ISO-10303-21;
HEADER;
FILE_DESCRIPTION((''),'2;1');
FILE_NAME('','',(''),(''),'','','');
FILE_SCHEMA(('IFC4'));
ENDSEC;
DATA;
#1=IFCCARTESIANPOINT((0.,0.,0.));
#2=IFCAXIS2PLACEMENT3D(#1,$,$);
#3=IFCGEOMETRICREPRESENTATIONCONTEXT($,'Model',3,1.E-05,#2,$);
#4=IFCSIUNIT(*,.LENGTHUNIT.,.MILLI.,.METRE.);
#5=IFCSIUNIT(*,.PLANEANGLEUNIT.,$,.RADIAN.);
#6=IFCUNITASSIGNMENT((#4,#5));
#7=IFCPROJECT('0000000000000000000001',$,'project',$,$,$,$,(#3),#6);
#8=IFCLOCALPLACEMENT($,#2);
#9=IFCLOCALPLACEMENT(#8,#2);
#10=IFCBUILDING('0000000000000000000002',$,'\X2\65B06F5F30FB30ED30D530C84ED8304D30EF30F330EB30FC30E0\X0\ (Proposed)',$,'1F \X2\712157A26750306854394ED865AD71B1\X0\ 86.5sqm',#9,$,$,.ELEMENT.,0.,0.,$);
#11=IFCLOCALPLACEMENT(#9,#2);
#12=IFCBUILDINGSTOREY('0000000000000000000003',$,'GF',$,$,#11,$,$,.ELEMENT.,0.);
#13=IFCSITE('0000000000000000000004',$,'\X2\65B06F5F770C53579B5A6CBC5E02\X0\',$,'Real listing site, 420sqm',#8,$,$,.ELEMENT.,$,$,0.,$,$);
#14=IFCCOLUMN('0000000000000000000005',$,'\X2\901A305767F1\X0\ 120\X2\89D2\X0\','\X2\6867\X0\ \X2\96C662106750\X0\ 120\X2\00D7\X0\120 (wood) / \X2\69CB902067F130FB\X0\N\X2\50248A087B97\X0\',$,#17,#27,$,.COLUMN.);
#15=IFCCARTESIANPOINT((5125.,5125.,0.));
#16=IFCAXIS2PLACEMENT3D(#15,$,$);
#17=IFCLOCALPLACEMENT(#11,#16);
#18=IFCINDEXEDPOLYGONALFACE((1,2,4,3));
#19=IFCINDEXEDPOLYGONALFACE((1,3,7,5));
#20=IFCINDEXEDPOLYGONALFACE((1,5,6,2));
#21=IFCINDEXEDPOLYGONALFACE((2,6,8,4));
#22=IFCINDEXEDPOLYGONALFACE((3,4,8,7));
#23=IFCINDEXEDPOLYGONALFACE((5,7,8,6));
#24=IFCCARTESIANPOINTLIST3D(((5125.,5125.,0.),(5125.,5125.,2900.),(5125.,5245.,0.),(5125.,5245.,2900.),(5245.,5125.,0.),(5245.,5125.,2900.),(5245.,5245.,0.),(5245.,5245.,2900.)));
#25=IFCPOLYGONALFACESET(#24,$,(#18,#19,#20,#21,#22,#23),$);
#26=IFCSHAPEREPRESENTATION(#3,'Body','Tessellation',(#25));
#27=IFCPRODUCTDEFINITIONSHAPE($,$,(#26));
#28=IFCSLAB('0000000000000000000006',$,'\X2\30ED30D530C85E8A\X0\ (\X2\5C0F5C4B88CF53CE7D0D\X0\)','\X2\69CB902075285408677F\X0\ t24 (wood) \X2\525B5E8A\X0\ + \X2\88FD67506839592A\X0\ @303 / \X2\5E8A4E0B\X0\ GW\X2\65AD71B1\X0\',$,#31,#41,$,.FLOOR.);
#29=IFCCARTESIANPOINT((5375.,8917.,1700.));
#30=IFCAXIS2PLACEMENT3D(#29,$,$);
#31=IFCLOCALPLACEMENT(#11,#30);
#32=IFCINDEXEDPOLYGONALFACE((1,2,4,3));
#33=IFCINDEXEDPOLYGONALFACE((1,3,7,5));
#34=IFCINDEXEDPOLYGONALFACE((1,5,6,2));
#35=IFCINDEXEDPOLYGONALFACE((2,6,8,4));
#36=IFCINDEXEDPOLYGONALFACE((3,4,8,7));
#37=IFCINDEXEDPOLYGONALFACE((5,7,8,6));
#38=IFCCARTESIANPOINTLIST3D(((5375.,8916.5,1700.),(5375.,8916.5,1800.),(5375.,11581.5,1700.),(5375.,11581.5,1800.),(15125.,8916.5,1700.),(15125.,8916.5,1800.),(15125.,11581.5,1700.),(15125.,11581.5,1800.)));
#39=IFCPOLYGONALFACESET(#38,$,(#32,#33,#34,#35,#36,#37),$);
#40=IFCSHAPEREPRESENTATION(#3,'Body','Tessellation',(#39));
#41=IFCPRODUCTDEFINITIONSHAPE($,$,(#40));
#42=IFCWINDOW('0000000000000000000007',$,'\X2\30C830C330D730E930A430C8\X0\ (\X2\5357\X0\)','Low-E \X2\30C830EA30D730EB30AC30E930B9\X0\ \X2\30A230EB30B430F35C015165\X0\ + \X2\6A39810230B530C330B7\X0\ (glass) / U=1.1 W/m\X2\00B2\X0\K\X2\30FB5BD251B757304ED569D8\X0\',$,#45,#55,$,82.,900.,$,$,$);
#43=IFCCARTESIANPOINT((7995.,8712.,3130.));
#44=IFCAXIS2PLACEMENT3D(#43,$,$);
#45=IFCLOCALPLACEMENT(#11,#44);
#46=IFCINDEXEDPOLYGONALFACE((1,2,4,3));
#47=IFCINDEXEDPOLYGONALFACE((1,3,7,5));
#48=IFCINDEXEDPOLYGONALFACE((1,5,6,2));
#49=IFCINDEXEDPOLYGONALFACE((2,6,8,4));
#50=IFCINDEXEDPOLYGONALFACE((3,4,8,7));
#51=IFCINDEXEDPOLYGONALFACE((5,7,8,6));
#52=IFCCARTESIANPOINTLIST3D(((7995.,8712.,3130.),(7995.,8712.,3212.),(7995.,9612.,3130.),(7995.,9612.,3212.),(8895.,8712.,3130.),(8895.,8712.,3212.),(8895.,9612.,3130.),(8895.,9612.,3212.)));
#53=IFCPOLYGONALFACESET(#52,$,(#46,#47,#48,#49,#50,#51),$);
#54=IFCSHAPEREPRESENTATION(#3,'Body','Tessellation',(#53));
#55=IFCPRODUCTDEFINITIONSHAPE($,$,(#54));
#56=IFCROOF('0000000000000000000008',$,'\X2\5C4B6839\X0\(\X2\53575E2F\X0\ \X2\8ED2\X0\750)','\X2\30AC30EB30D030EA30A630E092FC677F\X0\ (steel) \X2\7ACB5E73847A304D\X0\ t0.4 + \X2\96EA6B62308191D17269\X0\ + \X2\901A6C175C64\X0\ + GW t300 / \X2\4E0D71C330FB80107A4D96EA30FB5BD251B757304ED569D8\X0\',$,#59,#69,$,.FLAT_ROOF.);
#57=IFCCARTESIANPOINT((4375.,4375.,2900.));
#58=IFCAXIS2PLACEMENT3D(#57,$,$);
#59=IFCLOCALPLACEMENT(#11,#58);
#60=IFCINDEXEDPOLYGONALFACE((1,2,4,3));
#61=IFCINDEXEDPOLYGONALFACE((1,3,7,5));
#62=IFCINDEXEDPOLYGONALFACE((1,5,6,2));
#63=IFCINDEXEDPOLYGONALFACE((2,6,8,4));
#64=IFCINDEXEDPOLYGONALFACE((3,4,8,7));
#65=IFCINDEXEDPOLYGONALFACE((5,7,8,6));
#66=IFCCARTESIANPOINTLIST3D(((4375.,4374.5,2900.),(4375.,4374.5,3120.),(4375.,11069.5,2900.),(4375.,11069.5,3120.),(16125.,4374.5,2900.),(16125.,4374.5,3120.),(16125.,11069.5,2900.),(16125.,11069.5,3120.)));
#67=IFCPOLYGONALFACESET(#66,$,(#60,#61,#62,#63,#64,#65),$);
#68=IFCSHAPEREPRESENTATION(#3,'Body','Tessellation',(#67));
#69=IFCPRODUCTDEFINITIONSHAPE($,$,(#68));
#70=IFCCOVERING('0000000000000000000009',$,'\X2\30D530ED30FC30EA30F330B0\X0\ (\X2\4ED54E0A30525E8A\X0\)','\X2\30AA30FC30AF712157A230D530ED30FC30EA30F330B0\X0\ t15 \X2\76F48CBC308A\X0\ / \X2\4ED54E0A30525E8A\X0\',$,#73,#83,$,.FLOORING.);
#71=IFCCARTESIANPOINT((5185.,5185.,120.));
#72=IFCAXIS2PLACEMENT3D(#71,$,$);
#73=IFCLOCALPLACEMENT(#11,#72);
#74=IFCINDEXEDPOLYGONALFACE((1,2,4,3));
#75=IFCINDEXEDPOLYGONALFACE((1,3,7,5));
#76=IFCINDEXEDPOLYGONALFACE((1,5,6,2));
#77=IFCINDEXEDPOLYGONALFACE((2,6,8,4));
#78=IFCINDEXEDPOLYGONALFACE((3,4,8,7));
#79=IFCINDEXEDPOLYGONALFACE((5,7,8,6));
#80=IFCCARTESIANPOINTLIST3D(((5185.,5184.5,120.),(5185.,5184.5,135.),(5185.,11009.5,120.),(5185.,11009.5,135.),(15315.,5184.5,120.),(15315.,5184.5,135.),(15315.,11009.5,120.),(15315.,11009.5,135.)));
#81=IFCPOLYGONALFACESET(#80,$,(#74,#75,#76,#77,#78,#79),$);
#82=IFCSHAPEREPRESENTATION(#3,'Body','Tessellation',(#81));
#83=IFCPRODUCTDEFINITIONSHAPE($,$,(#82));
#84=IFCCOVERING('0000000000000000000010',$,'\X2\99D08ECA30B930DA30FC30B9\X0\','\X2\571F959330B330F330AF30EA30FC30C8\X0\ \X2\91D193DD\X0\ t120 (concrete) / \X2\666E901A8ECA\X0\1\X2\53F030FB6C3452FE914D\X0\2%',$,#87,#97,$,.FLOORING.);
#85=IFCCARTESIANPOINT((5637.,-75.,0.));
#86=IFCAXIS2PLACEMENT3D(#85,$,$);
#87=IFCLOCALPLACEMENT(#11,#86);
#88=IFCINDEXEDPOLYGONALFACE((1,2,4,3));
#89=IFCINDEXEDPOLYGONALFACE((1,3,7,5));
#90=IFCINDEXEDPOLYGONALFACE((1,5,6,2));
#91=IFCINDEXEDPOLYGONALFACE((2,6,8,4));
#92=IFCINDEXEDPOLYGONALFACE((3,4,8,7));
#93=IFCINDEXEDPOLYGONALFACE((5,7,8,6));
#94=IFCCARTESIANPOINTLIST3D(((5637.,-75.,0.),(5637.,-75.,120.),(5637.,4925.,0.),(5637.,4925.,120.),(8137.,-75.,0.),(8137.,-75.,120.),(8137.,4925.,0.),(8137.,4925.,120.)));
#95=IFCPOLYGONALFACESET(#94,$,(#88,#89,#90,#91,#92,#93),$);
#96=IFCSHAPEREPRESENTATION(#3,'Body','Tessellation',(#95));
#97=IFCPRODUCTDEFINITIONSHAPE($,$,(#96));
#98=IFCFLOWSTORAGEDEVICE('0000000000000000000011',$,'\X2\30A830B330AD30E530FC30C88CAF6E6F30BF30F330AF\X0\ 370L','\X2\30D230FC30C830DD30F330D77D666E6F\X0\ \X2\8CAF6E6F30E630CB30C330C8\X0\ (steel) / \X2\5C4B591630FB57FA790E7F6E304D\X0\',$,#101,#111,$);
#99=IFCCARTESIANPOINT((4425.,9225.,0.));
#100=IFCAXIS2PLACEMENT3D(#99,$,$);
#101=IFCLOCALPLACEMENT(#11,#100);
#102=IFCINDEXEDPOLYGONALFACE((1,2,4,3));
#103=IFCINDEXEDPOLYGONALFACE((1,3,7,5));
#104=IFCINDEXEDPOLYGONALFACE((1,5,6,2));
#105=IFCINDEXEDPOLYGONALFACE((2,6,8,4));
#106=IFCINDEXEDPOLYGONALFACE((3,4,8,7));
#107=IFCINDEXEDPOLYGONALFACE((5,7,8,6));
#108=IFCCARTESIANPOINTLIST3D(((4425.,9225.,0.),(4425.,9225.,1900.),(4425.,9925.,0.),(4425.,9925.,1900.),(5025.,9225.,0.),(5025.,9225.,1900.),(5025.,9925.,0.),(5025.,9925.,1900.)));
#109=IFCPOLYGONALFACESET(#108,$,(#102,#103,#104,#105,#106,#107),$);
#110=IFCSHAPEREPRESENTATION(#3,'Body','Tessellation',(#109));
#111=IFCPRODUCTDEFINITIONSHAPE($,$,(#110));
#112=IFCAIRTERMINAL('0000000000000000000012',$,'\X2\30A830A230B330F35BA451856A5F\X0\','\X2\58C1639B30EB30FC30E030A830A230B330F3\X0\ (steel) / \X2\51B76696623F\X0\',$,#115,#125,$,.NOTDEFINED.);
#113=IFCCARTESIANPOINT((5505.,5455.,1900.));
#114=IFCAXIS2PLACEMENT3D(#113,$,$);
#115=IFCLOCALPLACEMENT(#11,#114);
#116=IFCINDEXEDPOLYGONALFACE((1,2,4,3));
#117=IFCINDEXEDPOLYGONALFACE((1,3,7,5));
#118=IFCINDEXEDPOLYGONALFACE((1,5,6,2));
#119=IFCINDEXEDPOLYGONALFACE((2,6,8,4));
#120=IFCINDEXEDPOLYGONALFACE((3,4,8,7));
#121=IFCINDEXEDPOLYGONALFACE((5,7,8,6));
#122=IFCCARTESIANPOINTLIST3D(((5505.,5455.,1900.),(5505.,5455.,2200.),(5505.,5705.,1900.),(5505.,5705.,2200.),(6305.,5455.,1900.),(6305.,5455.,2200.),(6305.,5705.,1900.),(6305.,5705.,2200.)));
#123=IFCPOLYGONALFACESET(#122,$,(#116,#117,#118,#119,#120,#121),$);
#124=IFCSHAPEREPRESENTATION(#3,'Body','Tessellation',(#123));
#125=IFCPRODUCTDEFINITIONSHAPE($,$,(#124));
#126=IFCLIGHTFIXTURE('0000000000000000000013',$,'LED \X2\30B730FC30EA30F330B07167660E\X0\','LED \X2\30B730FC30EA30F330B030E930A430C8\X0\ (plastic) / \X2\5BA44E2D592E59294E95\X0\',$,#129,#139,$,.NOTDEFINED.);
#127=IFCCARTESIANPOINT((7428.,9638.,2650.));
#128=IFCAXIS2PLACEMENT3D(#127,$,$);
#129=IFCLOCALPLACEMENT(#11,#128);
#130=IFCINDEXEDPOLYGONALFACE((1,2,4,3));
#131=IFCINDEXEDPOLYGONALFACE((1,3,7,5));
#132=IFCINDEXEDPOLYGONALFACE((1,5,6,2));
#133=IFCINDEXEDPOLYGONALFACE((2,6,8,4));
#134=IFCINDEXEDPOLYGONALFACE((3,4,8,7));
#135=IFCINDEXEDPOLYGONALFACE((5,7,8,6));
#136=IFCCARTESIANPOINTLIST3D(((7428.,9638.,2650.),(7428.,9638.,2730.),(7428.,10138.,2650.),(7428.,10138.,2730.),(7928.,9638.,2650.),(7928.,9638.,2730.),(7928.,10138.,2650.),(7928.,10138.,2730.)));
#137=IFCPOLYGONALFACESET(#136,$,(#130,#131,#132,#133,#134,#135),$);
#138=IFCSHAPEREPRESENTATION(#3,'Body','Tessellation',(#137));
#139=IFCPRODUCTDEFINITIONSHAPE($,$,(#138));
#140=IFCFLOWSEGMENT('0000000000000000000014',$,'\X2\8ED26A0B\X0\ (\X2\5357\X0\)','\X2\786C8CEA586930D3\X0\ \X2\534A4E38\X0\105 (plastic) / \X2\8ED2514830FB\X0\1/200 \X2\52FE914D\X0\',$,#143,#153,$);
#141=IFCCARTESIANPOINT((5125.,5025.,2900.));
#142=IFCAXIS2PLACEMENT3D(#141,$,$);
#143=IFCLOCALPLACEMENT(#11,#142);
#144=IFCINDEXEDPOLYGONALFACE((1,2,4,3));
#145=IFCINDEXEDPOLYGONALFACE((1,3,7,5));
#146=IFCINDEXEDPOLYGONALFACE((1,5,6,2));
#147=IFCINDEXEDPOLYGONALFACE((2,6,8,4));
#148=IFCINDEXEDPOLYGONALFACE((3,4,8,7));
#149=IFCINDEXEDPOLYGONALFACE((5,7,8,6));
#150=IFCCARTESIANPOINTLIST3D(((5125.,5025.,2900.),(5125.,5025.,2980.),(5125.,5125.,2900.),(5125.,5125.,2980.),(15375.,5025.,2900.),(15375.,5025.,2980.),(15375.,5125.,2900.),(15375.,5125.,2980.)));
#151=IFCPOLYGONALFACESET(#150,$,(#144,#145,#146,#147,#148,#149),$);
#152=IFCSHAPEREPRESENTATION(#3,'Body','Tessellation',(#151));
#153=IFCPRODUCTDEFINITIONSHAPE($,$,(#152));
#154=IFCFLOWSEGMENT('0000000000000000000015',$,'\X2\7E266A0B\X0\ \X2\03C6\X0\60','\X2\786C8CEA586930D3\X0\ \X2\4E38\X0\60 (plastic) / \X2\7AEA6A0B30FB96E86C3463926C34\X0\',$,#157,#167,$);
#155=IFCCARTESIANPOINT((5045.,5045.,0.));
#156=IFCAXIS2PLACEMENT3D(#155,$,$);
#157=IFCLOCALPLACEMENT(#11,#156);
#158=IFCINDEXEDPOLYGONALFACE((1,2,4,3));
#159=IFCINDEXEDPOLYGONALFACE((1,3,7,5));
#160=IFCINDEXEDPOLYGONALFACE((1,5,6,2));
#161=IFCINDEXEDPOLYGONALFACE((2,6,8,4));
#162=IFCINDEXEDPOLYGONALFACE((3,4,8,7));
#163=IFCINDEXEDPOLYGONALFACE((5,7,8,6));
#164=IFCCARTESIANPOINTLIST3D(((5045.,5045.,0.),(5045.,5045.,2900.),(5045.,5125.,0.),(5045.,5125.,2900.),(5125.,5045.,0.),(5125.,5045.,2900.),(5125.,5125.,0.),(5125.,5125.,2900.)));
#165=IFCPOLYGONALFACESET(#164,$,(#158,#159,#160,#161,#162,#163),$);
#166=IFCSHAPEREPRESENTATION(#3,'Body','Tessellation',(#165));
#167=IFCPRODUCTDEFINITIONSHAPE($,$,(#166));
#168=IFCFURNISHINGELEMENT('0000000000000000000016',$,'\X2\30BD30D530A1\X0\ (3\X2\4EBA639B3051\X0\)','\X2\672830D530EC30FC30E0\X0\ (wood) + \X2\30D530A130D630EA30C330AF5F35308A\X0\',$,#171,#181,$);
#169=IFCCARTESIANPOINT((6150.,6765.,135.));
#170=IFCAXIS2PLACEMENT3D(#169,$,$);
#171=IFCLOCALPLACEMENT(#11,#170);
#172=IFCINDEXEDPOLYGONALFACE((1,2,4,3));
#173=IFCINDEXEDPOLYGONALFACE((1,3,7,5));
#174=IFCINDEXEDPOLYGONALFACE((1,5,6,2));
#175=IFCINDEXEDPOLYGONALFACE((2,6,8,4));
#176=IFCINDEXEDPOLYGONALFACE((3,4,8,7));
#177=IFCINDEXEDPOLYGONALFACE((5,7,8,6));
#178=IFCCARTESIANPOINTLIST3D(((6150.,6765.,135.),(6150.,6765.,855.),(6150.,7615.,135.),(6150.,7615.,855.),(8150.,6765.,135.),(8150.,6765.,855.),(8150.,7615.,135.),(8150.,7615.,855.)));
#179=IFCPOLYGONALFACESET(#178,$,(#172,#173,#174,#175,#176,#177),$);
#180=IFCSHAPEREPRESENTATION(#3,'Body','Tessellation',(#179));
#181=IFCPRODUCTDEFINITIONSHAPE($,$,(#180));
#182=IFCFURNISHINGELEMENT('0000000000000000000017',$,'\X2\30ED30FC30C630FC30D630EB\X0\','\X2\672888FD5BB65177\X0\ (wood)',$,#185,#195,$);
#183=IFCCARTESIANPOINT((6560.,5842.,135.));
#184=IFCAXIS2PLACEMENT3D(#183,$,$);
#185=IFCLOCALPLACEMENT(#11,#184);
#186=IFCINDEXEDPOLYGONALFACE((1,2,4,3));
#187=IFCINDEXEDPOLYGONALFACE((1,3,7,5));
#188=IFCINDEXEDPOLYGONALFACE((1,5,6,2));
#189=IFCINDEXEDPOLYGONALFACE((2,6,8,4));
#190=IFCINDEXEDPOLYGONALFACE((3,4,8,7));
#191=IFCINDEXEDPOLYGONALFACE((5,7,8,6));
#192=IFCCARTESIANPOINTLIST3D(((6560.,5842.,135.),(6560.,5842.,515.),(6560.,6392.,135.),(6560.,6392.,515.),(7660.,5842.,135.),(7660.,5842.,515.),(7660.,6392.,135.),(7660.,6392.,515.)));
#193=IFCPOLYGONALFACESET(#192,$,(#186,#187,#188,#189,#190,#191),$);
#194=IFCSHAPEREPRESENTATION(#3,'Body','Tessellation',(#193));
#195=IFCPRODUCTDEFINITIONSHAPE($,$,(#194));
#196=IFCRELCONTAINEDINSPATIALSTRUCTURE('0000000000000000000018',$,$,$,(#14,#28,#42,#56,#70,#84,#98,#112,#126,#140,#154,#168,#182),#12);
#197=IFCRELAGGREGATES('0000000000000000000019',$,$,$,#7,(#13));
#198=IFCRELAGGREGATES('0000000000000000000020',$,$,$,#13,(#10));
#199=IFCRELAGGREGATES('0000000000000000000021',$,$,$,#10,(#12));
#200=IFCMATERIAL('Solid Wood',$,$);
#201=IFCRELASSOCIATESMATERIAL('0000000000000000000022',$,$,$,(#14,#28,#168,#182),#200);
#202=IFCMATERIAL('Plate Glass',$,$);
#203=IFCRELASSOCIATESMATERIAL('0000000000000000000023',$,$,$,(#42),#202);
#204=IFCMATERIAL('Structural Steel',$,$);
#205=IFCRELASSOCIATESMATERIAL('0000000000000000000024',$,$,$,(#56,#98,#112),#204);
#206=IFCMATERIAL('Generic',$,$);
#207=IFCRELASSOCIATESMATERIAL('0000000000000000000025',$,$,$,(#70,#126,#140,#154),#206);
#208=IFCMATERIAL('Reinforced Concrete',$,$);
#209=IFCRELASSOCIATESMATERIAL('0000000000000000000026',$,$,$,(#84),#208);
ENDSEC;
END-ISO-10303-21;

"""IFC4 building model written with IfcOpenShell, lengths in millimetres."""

from ifc_helpers import new_model, si_unit, frame, frame_2d, origin, place, context, project, spatial, rectangle, extrude, material, element, save


model = new_model("IFC4")

# Units and contexts
model_context = context("Model", 3, precision=1e-05, world=origin())
ifc_project = project(units=[si_unit("LENGTHUNIT", "METRE", prefix="MILLI"), si_unit("PLANEANGLEUNIT", "RADIAN")], contexts=[model_context])

# Site, building, storey
site_placement = place(None, origin())
site = spatial("IfcSite", under=ifc_project, at=site_placement, Name="新潟県南魚沼市", ObjectType="Real listing site, 420sqm", CompositionType="ELEMENT", RefElevation=0.0)
building_placement = place(site_placement, origin())
building = spatial("IfcBuilding", under=site, at=building_placement, Name="新潟・ロフト付きワンルーム (Proposed)", ObjectType="1F 無垢材と吹付断熱 86.5sqm", CompositionType="ELEMENT", ElevationOfRefHeight=0.0, ElevationOfTerrain=0.0)
storey_placement = place(building_placement, origin())
storey = spatial("IfcBuildingStorey", under=building, at=storey_placement, Name="GF", CompositionType="ELEMENT", Elevation=0.0)

# Column
ifc_material_1 = material(Name="Solid Wood")
column_1_placement = place(storey_placement, frame((5125.0, 5125.0, 0.0)))
element("IfcColumn", 1, at=column_1_placement, inside=storey, material=ifc_material_1, Name="通し柱 120角", Description="桧 集成材 120×120 (wood) / 構造柱・N値計算", PredefinedType="COLUMN", context=model_context, shape_type="SweptSolid", body=[
    extrude(rectangle(XDim=120.0, YDim=120.0, at=frame_2d((60.0, 60.0))), frame((5125.0, 5125.0, 0.0)), (0.0, 0.0, 1.0), 2900.0),
])

# Slab
ifc_material_2 = material(Name="Reinforced Concrete")
slab_1_placement = place(storey_placement, frame((5375.0, 8917.0, 1700.0)))
element("IfcSlab", 2, at=slab_1_placement, inside=storey, material=ifc_material_1, Name="ロフト床 (小屋裏収納)", Description="構造用合板 t24 (wood) 剛床 + 製材根太 @303 / 床下 GW断熱", PredefinedType="FLOOR", context=model_context, shape_type="SweptSolid", body=[
    extrude(rectangle(XDim=9750.0, YDim=2665.0, at=frame_2d((4875.0, 1332.0))), frame((5375.0, 8917.0, 1700.0)), (0.0, 0.0, 1.0), 100.0),
])

# Shared definitions
ifc_material_3 = material(Name="Plate Glass")

# Window
window_1_placement = place(storey_placement, frame((7995.0, 8712.0, 3130.0)))
element("IfcWindow", 3, at=window_1_placement, inside=storey, material=ifc_material_3, Name="トップライト (南)", Description="Low-E トリプルガラス アルゴン封入 + 樹脂サッシ (glass) / U=1.1 W/m²K・寒冷地仕様", OverallHeight=82.0, OverallWidth=900.0, context=model_context, shape_type="SweptSolid", body=[
    extrude(rectangle(XDim=900.0, YDim=900.0, at=frame_2d((450.0, 450.0))), frame((7995.0, 8712.0, 3130.0)), (0.0, 0.0, 1.0), 82.0),
])

# Roof
ifc_material_4 = material(Name="Structural Steel")
roof_placement = place(storey_placement, frame((4375.0, 4375.0, 2900.0)))
element("IfcRoof", 4, at=roof_placement, inside=storey, material=ifc_material_4, Name="屋根(南帯 軒750)", Description="ガルバリウム鋼板 (steel) 立平葺き t0.4 + 雪止め金物 + 通気層 + GW t300 / 不燃・耐積雪・寒冷地仕様", PredefinedType="FLAT_ROOF", context=model_context, shape_type="SweptSolid", body=[
    extrude(rectangle(XDim=11750.0, YDim=6695.0, at=frame_2d((5875.0, 3347.0))), frame((4375.0, 4375.0, 2900.0)), (0.0, 0.0, 1.0), 220.0),
])

# Coverings
ifc_material_5 = material(Name="Generic")
covering_1_placement = place(storey_placement, frame((5185.0, 5185.0, 120.0)))
element("IfcCovering", 5, at=covering_1_placement, inside=storey, material=ifc_material_5, Name="フローリング (仕上げ床)", Description="オーク無垢フローリング t15 直貼り / 仕上げ床", PredefinedType="FLOORING", context=model_context, shape_type="SweptSolid", body=[
    extrude(rectangle(XDim=10130.0, YDim=5825.0, at=frame_2d((5065.0, 2912.0))), frame((5185.0, 5185.0, 120.0)), (0.0, 0.0, 1.0), 15.0),
])
covering_2_placement = place(storey_placement, frame((5637.0, -75.0, 0.0)))
element("IfcCovering", 6, at=covering_2_placement, inside=storey, material=ifc_material_2, Name="駐車スペース", Description="土間コンクリート 金鏝 t120 (concrete) / 普通車1台・水勾配2%", PredefinedType="FLOORING", context=model_context, shape_type="SweptSolid", body=[
    extrude(rectangle(XDim=2500.0, YDim=5000.0, at=frame_2d((1250.0, 2500.0))), frame((5637.0, -75.0, 0.0)), (0.0, 0.0, 1.0), 120.0),
])

# Flow storage device
flow_storage_device_placement = place(storey_placement, frame((4425.0, 9225.0, 0.0)))
element("IfcFlowStorageDevice", 7, at=flow_storage_device_placement, inside=storey, material=ifc_material_4, Name="エコキュート貯湯タンク 370L", Description="ヒートポンプ給湯 貯湯ユニット (steel) / 屋外・基礎置き", context=model_context, shape_type="SweptSolid", body=[
    extrude(rectangle(XDim=600.0, YDim=700.0, at=frame_2d((300.0, 350.0))), frame((4425.0, 9225.0, 0.0)), (0.0, 0.0, 1.0), 1900.0),
])

# Air terminal
air_terminal_placement = place(storey_placement, frame((5505.0, 5455.0, 1900.0)))
element("IfcAirTerminal", 8, at=air_terminal_placement, inside=storey, material=ifc_material_4, Name="エアコン室内機", Description="壁掛ルームエアコン (steel) / 冷暖房", PredefinedType="NOTDEFINED", context=model_context, shape_type="SweptSolid", body=[
    extrude(rectangle(XDim=800.0, YDim=250.0, at=frame_2d((400.0, 125.0))), frame((5505.0, 5455.0, 1900.0)), (0.0, 0.0, 1.0), 300.0),
])

# Light fixture
light_fixture_placement = place(storey_placement, frame((7428.0, 9638.0, 2650.0)))
element("IfcLightFixture", 9, at=light_fixture_placement, inside=storey, material=ifc_material_5, Name="LED シーリング照明", Description="LED シーリングライト (plastic) / 室中央天井", PredefinedType="NOTDEFINED", context=model_context, shape_type="SweptSolid", body=[
    extrude(rectangle(XDim=500.0, YDim=500.0, at=frame_2d((250.0, 250.0))), frame((7428.0, 9638.0, 2650.0)), (0.0, 0.0, 1.0), 80.0),
])

# Flow segments
flow_segment_1_placement = place(storey_placement, frame((5125.0, 5025.0, 2900.0)))
element("IfcFlowSegment", 10, at=flow_segment_1_placement, inside=storey, material=ifc_material_5, Name="軒樋 (南)", Description="硬質塩ビ 半丸105 (plastic) / 軒先・1/200 勾配", context=model_context, shape_type="SweptSolid", body=[
    extrude(rectangle(XDim=10250.0, YDim=100.0, at=frame_2d((5125.0, 50.0))), frame((5125.0, 5025.0, 2900.0)), (0.0, 0.0, 1.0), 80.0),
])
flow_segment_2_placement = place(storey_placement, frame((5045.0, 5045.0, 0.0)))
element("IfcFlowSegment", 11, at=flow_segment_2_placement, inside=storey, material=ifc_material_5, Name="縦樋 φ60", Description="硬質塩ビ 丸60 (plastic) / 竪樋・雨水排水", context=model_context, shape_type="SweptSolid", body=[
    extrude(rectangle(XDim=80.0, YDim=80.0, at=frame_2d((40.0, 40.0))), frame((5045.0, 5045.0, 0.0)), (0.0, 0.0, 1.0), 2900.0),
])

# Furnishing elements
furnishing_1_placement = place(storey_placement, frame((6150.0, 6765.0, 135.0)))
element("IfcFurnishingElement", 12, at=furnishing_1_placement, inside=storey, material=ifc_material_1, Name="ソファ (3人掛け)", Description="木フレーム (wood) + ファブリック張り", context=model_context, shape_type="SweptSolid", body=[
    extrude(rectangle(XDim=2000.0, YDim=850.0, at=frame_2d((1000.0, 425.0))), frame((6150.0, 6765.0, 135.0)), (0.0, 0.0, 1.0), 720.0),
])
furnishing_2_placement = place(storey_placement, frame((6560.0, 5842.0, 135.0)))
element("IfcFurnishingElement", 13, at=furnishing_2_placement, inside=storey, material=ifc_material_1, Name="ローテーブル", Description="木製家具 (wood)", context=model_context, shape_type="SweptSolid", body=[
    extrude(rectangle(XDim=1100.0, YDim=550.0, at=frame_2d((550.0, 275.0))), frame((6560.0, 5842.0, 135.0)), (0.0, 0.0, 1.0), 380.0),
])

save(model, "model.ifc")
